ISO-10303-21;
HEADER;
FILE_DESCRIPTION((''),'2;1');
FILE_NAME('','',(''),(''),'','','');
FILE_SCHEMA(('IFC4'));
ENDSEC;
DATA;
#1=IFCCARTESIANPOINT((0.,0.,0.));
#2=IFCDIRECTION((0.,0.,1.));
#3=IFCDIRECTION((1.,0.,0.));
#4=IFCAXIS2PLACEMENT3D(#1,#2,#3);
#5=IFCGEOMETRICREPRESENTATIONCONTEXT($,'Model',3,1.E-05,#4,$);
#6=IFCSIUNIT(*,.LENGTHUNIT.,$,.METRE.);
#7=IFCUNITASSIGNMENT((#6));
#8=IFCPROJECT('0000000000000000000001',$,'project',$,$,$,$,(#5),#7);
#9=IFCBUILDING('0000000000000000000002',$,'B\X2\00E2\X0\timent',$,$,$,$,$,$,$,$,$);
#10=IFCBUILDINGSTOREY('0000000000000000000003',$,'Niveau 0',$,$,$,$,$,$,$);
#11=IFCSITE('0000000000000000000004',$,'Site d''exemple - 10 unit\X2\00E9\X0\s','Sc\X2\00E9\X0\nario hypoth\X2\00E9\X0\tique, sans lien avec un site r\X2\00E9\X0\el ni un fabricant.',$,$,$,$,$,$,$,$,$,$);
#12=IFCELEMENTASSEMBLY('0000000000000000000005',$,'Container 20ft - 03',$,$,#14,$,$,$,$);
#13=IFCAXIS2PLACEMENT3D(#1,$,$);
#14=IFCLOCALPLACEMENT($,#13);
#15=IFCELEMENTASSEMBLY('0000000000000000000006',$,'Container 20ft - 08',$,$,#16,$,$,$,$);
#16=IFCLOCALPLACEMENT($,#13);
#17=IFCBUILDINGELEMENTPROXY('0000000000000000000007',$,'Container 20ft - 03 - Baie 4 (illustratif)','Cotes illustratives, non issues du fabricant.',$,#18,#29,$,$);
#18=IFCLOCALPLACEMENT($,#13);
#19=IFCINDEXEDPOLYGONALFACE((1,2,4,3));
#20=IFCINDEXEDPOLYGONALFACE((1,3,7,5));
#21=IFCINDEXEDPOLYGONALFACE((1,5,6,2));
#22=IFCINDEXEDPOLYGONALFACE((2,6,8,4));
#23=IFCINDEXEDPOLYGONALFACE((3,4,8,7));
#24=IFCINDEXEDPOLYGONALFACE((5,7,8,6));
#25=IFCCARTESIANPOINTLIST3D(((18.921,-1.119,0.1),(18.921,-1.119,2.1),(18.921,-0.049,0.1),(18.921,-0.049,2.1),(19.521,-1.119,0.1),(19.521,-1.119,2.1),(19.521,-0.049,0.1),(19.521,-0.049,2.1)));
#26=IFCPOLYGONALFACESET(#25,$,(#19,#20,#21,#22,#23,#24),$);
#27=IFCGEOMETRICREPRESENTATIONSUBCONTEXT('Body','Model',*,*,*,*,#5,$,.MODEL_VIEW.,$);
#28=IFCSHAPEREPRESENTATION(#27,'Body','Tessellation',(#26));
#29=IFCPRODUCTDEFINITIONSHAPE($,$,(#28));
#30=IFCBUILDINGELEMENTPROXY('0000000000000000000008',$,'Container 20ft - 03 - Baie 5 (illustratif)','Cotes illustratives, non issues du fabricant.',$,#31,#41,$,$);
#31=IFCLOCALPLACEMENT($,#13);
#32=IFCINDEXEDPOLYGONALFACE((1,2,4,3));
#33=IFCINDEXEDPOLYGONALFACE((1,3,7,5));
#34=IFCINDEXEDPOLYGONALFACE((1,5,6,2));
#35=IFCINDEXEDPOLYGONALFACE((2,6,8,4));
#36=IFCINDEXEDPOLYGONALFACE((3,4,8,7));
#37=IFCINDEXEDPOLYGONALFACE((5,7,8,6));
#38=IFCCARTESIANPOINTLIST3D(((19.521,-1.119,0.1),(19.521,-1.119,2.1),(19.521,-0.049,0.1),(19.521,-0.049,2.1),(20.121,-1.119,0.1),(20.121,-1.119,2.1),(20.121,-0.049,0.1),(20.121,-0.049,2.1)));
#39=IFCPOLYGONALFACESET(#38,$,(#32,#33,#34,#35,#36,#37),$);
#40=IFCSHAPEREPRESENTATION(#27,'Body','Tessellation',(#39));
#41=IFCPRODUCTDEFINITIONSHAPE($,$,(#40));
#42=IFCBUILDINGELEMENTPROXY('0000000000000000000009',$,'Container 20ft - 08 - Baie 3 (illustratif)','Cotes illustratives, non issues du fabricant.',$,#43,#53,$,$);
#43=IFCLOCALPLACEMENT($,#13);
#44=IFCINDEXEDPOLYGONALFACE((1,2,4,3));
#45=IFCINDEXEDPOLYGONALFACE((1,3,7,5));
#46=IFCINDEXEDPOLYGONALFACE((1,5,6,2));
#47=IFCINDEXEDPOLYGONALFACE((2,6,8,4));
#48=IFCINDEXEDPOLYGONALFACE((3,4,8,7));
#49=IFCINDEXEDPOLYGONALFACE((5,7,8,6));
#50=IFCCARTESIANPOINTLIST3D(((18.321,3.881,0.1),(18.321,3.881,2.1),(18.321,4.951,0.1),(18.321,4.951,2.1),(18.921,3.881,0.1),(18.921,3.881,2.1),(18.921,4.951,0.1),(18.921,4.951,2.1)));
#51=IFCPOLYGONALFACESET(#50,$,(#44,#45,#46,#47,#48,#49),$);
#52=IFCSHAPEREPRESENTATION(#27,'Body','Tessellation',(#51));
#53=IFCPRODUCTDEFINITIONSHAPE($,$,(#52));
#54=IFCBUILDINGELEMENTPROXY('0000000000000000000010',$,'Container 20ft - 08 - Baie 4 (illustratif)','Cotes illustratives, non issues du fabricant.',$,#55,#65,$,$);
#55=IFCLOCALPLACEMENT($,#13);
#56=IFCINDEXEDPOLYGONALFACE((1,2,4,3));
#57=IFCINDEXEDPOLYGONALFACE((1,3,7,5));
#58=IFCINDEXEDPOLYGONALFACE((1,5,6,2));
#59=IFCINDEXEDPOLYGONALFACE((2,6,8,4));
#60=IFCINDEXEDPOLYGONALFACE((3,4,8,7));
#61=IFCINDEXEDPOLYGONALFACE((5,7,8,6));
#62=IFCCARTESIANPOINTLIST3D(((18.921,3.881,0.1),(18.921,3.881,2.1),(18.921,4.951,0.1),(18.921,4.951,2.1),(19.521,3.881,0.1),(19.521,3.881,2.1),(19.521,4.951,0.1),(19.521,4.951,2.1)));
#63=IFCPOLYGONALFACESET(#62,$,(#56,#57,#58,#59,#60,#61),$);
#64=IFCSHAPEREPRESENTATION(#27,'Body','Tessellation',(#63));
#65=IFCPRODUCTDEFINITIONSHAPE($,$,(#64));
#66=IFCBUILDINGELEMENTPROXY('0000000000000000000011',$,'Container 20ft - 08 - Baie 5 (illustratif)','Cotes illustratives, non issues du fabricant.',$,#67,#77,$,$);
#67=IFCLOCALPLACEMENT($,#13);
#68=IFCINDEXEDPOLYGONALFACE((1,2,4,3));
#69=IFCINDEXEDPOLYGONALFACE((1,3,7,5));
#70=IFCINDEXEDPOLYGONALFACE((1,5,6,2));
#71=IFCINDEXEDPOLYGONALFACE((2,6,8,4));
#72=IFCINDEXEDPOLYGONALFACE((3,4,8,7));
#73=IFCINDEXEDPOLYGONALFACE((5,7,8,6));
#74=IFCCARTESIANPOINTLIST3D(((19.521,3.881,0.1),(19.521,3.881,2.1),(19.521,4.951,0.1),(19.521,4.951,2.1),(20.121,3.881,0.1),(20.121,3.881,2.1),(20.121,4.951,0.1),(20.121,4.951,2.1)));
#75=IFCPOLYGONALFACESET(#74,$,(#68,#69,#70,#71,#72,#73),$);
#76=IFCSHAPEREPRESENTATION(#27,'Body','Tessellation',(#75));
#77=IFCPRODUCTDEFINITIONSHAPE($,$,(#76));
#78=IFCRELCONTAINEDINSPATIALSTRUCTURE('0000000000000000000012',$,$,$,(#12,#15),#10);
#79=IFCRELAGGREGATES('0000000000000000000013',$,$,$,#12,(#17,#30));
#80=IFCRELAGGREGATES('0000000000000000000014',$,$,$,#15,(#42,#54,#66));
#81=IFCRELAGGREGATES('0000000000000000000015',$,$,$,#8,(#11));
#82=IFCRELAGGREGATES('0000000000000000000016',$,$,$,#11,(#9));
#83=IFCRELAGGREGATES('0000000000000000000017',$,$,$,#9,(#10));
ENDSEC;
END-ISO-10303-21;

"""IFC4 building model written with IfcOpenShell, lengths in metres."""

from ifc_helpers import new_model, si_unit, frame, origin_with_axes, place, context, subcontext, project, spatial, rectangle, extrude, element, aggregate, save


model = new_model("IFC4")

# Units and contexts
model_context = context("Model", 3, precision=1e-05, world=origin_with_axes())
body_context = subcontext(model_context, "Body", "Model", "MODEL_VIEW")
ifc_project = project(units=[si_unit("LENGTHUNIT", "METRE")], contexts=[model_context])

# Site, building, storey
site = spatial("IfcSite", under=ifc_project, Name="Site d'exemple - 10 unités", Description="Scénario hypothétique, sans lien avec un site réel ni un fabricant.")
building = spatial("IfcBuilding", under=site, Name="Bâtiment")
storey = spatial("IfcBuildingStorey", under=building, Name="Niveau 0")

# Element assembly
assembly_1 = element("IfcElementAssembly", 1, inside=storey, Name="Container 20ft - 03")

# Element assembly
assembly_2 = element("IfcElementAssembly", 2, inside=storey, Name="Container 20ft - 08")

# Building element proxies
proxy_1_placement = place(None, frame((19.221, -0.584, 0.1), z_axis=(0.0, 0.0, 1.0), x_axis=(1.0, 0.0, 0.0)))
proxy_1 = element("IfcBuildingElementProxy", 3, at=proxy_1_placement, Name="Container 20ft - 03 - Baie 4 (illustratif)", Description="Cotes illustratives, non issues du fabricant.", context=body_context, shape_type="SweptSolid", body=[
    extrude(rectangle(XDim=0.6, YDim=1.07), origin_with_axes(), (0.0, 0.0, 1.0), 2.0),
])
proxy_2_placement = place(None, frame((19.821, -0.584, 0.1), z_axis=(0.0, 0.0, 1.0), x_axis=(1.0, 0.0, 0.0)))
proxy_2 = element("IfcBuildingElementProxy", 4, at=proxy_2_placement, Name="Container 20ft - 03 - Baie 5 (illustratif)", Description="Cotes illustratives, non issues du fabricant.", context=body_context, shape_type="SweptSolid", body=[
    extrude(rectangle(XDim=0.6, YDim=1.07), origin_with_axes(), (0.0, 0.0, 1.0), 2.0),
])
aggregate(assembly_1, [proxy_1, proxy_2])
proxy_3_placement = place(None, frame((18.621, 4.416, 0.1), z_axis=(0.0, 0.0, 1.0), x_axis=(1.0, 0.0, 0.0)))
proxy_3 = element("IfcBuildingElementProxy", 5, at=proxy_3_placement, Name="Container 20ft - 08 - Baie 3 (illustratif)", Description="Cotes illustratives, non issues du fabricant.", context=body_context, shape_type="SweptSolid", body=[
    extrude(rectangle(XDim=0.6, YDim=1.07), origin_with_axes(), (0.0, 0.0, 1.0), 2.0),
])
proxy_4_placement = place(None, frame((19.221, 4.416, 0.1), z_axis=(0.0, 0.0, 1.0), x_axis=(1.0, 0.0, 0.0)))
proxy_4 = element("IfcBuildingElementProxy", 6, at=proxy_4_placement, Name="Container 20ft - 08 - Baie 4 (illustratif)", Description="Cotes illustratives, non issues du fabricant.", context=body_context, shape_type="SweptSolid", body=[
    extrude(rectangle(XDim=0.6, YDim=1.07), origin_with_axes(), (0.0, 0.0, 1.0), 2.0),
])
proxy_5_placement = place(None, frame((19.821, 4.416, 0.1), z_axis=(0.0, 0.0, 1.0), x_axis=(1.0, 0.0, 0.0)))
proxy_5 = element("IfcBuildingElementProxy", 7, at=proxy_5_placement, Name="Container 20ft - 08 - Baie 5 (illustratif)", Description="Cotes illustratives, non issues du fabricant.", context=body_context, shape_type="SweptSolid", body=[
    extrude(rectangle(XDim=0.6, YDim=1.07), origin_with_axes(), (0.0, 0.0, 1.0), 2.0),
])
aggregate(assembly_2, [proxy_3, proxy_4, proxy_5])

save(model, "model.ifc")
